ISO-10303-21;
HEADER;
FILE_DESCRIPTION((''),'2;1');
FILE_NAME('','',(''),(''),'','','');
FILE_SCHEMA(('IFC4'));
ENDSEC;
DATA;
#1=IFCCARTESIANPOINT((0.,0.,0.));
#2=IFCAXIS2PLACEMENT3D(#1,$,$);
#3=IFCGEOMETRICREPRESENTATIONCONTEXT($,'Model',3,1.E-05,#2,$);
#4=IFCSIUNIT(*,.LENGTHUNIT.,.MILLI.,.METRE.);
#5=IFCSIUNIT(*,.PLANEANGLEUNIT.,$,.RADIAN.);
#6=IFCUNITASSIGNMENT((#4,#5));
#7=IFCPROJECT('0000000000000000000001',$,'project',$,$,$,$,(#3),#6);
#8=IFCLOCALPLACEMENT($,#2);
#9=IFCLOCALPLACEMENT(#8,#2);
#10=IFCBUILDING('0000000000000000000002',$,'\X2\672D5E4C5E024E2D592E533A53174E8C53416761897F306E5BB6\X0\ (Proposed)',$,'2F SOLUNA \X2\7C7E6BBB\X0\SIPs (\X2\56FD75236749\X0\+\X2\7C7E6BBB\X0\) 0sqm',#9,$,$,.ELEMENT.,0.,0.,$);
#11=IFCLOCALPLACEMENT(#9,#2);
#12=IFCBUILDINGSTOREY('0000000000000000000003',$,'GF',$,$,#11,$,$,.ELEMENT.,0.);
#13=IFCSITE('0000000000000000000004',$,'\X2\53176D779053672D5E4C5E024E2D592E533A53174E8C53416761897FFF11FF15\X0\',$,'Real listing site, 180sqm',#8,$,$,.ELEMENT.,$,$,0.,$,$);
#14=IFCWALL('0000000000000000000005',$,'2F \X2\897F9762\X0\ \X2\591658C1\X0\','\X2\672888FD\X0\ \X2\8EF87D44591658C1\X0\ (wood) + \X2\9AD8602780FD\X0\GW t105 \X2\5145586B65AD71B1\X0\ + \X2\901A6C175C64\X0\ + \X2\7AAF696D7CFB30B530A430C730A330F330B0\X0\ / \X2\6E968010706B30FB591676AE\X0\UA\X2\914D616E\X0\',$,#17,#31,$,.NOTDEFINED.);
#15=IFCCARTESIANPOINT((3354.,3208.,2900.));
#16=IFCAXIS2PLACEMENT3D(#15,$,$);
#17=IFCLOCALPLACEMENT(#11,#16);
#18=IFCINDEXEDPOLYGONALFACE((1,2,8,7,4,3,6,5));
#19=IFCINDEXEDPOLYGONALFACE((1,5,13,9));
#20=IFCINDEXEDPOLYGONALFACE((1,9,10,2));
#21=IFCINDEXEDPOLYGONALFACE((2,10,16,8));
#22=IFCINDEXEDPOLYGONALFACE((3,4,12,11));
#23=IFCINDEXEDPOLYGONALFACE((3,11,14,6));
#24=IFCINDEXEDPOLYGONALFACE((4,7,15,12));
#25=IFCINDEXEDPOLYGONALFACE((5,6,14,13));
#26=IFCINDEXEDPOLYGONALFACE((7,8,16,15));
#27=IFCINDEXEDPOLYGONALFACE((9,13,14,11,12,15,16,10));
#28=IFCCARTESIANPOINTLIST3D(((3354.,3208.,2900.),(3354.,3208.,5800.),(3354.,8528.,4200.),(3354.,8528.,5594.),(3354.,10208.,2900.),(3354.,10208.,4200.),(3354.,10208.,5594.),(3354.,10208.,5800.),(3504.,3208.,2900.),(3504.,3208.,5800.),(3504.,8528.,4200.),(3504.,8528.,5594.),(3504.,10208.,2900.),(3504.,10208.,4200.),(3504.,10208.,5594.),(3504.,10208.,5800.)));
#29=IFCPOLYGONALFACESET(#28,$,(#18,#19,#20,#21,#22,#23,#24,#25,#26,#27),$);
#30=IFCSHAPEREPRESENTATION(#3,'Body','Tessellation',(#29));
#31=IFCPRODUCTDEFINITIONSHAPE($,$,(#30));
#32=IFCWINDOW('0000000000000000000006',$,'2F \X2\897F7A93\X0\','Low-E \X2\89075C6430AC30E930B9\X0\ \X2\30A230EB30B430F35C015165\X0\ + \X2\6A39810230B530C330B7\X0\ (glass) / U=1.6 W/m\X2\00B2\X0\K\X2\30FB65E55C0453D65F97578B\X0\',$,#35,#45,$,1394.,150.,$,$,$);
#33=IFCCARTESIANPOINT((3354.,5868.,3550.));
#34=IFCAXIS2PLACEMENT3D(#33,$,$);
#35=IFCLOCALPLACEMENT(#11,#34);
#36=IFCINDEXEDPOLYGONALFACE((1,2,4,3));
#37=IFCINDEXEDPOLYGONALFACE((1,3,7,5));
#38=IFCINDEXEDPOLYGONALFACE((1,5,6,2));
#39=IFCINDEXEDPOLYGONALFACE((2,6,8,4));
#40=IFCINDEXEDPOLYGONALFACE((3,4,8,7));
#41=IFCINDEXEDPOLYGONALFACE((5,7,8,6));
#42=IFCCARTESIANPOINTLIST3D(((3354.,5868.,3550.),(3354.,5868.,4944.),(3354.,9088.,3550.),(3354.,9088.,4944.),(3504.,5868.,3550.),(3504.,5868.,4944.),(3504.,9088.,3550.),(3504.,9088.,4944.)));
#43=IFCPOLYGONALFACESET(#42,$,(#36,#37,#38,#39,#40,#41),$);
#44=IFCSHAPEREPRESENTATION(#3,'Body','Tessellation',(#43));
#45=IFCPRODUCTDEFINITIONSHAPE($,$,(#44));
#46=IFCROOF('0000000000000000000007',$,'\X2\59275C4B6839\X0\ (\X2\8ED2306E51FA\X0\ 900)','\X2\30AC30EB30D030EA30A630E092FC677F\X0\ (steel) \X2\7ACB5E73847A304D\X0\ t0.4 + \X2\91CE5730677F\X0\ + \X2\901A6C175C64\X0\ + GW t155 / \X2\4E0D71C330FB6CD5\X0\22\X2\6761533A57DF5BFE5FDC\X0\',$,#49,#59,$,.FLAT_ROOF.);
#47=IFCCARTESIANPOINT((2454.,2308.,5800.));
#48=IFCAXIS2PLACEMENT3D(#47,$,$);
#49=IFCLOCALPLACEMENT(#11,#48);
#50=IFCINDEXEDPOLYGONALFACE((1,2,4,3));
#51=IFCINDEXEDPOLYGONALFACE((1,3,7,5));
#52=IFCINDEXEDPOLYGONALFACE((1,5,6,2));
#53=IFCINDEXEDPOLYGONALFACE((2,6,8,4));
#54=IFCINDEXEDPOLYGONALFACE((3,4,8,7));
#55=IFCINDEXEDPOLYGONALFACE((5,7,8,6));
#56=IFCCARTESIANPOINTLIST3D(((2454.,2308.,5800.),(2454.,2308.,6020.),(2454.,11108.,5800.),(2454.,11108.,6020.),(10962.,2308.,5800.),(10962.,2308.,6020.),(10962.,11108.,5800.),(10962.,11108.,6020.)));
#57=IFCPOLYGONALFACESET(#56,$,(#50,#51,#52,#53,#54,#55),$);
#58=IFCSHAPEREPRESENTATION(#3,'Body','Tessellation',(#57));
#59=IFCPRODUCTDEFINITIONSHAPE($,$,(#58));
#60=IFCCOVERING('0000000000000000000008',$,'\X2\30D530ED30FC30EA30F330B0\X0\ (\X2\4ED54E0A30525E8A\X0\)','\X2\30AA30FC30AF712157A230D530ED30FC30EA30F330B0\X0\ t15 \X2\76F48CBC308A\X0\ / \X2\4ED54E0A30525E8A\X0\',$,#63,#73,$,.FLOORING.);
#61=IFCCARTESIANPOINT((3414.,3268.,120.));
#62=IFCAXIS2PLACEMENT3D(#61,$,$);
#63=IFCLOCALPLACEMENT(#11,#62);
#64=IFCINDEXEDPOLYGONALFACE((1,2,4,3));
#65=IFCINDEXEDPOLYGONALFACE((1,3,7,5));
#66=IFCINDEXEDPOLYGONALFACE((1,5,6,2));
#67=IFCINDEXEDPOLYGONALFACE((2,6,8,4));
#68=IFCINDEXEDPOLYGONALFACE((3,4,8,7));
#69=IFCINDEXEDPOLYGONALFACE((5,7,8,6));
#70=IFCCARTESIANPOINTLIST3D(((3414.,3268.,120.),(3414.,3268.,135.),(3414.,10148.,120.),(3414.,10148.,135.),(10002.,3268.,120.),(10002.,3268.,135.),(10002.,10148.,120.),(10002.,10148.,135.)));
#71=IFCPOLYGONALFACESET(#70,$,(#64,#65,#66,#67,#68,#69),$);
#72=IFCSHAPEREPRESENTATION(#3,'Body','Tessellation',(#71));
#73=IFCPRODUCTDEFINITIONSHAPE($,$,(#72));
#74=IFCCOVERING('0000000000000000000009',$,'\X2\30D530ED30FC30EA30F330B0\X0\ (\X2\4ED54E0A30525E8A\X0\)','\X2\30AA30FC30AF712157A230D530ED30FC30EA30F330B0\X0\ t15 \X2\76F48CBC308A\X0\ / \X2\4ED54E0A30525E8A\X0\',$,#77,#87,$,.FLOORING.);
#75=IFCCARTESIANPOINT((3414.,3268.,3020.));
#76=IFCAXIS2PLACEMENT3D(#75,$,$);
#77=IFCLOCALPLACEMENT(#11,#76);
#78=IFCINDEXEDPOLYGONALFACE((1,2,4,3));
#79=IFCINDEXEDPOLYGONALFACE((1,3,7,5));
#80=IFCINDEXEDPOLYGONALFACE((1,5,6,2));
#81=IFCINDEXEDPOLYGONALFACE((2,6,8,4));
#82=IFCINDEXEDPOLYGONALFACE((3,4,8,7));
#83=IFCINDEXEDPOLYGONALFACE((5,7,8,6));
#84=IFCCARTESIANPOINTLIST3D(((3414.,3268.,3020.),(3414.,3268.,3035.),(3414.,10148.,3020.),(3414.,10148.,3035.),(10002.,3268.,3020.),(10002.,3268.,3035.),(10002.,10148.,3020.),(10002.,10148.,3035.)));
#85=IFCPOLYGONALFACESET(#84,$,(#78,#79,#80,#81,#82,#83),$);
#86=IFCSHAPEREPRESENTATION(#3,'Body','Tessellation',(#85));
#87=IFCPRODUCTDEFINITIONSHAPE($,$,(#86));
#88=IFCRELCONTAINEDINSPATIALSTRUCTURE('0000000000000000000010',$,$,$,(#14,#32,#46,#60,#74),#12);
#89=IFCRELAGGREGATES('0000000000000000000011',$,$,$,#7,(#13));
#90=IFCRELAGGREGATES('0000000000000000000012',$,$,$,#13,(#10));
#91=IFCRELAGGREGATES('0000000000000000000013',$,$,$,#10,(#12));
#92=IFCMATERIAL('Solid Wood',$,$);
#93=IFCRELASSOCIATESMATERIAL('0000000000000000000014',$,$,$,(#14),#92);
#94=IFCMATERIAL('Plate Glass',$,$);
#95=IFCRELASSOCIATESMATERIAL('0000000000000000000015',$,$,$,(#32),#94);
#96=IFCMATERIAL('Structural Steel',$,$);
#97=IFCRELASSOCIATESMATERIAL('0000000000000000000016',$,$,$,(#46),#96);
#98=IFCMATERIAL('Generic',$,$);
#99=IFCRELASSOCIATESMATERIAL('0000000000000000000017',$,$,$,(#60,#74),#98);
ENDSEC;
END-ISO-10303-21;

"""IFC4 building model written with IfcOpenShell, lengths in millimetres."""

from ifc_helpers import new_model, si_unit, frame, frame_2d, origin, place, context, project, spatial, rectangle, extrude, material, element, fill, save


model = new_model("IFC4")

# Units and contexts
model_context = context("Model", 3, precision=1e-05, world=origin())
ifc_project = project(units=[si_unit("LENGTHUNIT", "METRE", prefix="MILLI"), si_unit("PLANEANGLEUNIT", "RADIAN")], contexts=[model_context])

# Site, building, storey
site_placement = place(None, origin())
site = spatial("IfcSite", under=ifc_project, at=site_placement, Name="北海道札幌市中央区北二十条西１５", ObjectType="Real listing site, 180sqm", CompositionType="ELEMENT", RefElevation=0.0)
building_placement = place(site_placement, origin())
building = spatial("IfcBuilding", under=site, at=building_placement, Name="札幌市中央区北二十条西の家 (Proposed)", ObjectType="2F SOLUNA 籾殻SIPs (国産杉+籾殻) 0sqm", CompositionType="ELEMENT", ElevationOfRefHeight=0.0, ElevationOfTerrain=0.0)
storey_placement = place(building_placement, origin())
storey = spatial("IfcBuildingStorey", under=building, at=storey_placement, Name="GF", CompositionType="ELEMENT", Elevation=0.0)

# Shared definitions
ifc_material_1 = material(Name="Solid Wood")

# Shared definitions
ifc_material_2 = material(Name="Plate Glass")

# Wall, opening, window
wall_1_placement = place(storey_placement, frame((3354.0, 3208.0, 2900.0)))
wall_1 = element("IfcWall", 1, at=wall_1_placement, inside=storey, material=ifc_material_1, Name="2F 西面 外壁", Description="木製 軸組外壁 (wood) + 高性能GW t105 充填断熱 + 通気層 + 窯業系サイディング / 準耐火・外皮UA配慮", PredefinedType="NOTDEFINED", context=model_context, shape_type="SweptSolid", body=[
    extrude(rectangle(XDim=150.0, YDim=7000.0, at=frame_2d((75.0, 3500.0))), frame((3354.0, 3208.0, 2900.0)), (0.0, 0.0, 1.0), 2900.0),
])
opening_1_placement = place(storey_placement, frame((3354.0, 5868.0, 3550.0)))
opening_1 = element("IfcOpeningElement", 2, at=opening_1_placement, cuts=wall_1, PredefinedType="NOTDEFINED", context=model_context, shape_type="SweptSolid", body=[
    extrude(rectangle(XDim=150.0, YDim=3220.0, at=frame_2d((75.0, 1610.0))), frame((3354.0, 5868.0, 3550.0)), (0.0, 0.0, 1.0), 1394.0),
])
window_1_placement = place(storey_placement, frame((3354.0, 5868.0, 3550.0)))
window_1 = element("IfcWindow", 3, at=window_1_placement, inside=storey, material=ifc_material_2, Name="2F 西窓", Description="Low-E 複層ガラス アルゴン封入 + 樹脂サッシ (glass) / U=1.6 W/m²K・日射取得型", OverallHeight=1394.0, OverallWidth=150.0, context=model_context, shape_type="SweptSolid", body=[
    extrude(rectangle(XDim=150.0, YDim=3220.0, at=frame_2d((75.0, 1610.0))), frame((3354.0, 5868.0, 3550.0)), (0.0, 0.0, 1.0), 1394.0),
])
fill(opening_1, window_1)

# Roof
ifc_material_3 = material(Name="Structural Steel")
roof_placement = place(storey_placement, frame((2454.0, 2308.0, 5800.0)))
element("IfcRoof", 4, at=roof_placement, inside=storey, material=ifc_material_3, Name="大屋根 (軒の出 900)", Description="ガルバリウム鋼板 (steel) 立平葺き t0.4 + 野地板 + 通気層 + GW t155 / 不燃・法22条区域対応", PredefinedType="FLAT_ROOF", context=model_context, shape_type="SweptSolid", body=[
    extrude(rectangle(XDim=8508.0, YDim=8800.0, at=frame_2d((4254.0, 4400.0))), frame((2454.0, 2308.0, 5800.0)), (0.0, 0.0, 1.0), 220.0),
])

# Coverings
ifc_material_4 = material(Name="Generic")
covering_1_placement = place(storey_placement, frame((3414.0, 3268.0, 120.0)))
element("IfcCovering", 5, at=covering_1_placement, inside=storey, material=ifc_material_4, Name="フローリング (仕上げ床)", Description="オーク無垢フローリング t15 直貼り / 仕上げ床", PredefinedType="FLOORING", context=model_context, shape_type="SweptSolid", body=[
    extrude(rectangle(XDim=6588.0, YDim=6880.0, at=frame_2d((3294.0, 3440.0))), frame((3414.0, 3268.0, 120.0)), (0.0, 0.0, 1.0), 15.0),
])
covering_2_placement = place(storey_placement, frame((3414.0, 3268.0, 3020.0)))
element("IfcCovering", 6, at=covering_2_placement, inside=storey, material=ifc_material_4, Name="フローリング (仕上げ床)", Description="オーク無垢フローリング t15 直貼り / 仕上げ床", PredefinedType="FLOORING", context=model_context, shape_type="SweptSolid", body=[
    extrude(rectangle(XDim=6588.0, YDim=6880.0, at=frame_2d((3294.0, 3440.0))), frame((3414.0, 3268.0, 3020.0)), (0.0, 0.0, 1.0), 15.0),
])

save(model, "model.ifc")
